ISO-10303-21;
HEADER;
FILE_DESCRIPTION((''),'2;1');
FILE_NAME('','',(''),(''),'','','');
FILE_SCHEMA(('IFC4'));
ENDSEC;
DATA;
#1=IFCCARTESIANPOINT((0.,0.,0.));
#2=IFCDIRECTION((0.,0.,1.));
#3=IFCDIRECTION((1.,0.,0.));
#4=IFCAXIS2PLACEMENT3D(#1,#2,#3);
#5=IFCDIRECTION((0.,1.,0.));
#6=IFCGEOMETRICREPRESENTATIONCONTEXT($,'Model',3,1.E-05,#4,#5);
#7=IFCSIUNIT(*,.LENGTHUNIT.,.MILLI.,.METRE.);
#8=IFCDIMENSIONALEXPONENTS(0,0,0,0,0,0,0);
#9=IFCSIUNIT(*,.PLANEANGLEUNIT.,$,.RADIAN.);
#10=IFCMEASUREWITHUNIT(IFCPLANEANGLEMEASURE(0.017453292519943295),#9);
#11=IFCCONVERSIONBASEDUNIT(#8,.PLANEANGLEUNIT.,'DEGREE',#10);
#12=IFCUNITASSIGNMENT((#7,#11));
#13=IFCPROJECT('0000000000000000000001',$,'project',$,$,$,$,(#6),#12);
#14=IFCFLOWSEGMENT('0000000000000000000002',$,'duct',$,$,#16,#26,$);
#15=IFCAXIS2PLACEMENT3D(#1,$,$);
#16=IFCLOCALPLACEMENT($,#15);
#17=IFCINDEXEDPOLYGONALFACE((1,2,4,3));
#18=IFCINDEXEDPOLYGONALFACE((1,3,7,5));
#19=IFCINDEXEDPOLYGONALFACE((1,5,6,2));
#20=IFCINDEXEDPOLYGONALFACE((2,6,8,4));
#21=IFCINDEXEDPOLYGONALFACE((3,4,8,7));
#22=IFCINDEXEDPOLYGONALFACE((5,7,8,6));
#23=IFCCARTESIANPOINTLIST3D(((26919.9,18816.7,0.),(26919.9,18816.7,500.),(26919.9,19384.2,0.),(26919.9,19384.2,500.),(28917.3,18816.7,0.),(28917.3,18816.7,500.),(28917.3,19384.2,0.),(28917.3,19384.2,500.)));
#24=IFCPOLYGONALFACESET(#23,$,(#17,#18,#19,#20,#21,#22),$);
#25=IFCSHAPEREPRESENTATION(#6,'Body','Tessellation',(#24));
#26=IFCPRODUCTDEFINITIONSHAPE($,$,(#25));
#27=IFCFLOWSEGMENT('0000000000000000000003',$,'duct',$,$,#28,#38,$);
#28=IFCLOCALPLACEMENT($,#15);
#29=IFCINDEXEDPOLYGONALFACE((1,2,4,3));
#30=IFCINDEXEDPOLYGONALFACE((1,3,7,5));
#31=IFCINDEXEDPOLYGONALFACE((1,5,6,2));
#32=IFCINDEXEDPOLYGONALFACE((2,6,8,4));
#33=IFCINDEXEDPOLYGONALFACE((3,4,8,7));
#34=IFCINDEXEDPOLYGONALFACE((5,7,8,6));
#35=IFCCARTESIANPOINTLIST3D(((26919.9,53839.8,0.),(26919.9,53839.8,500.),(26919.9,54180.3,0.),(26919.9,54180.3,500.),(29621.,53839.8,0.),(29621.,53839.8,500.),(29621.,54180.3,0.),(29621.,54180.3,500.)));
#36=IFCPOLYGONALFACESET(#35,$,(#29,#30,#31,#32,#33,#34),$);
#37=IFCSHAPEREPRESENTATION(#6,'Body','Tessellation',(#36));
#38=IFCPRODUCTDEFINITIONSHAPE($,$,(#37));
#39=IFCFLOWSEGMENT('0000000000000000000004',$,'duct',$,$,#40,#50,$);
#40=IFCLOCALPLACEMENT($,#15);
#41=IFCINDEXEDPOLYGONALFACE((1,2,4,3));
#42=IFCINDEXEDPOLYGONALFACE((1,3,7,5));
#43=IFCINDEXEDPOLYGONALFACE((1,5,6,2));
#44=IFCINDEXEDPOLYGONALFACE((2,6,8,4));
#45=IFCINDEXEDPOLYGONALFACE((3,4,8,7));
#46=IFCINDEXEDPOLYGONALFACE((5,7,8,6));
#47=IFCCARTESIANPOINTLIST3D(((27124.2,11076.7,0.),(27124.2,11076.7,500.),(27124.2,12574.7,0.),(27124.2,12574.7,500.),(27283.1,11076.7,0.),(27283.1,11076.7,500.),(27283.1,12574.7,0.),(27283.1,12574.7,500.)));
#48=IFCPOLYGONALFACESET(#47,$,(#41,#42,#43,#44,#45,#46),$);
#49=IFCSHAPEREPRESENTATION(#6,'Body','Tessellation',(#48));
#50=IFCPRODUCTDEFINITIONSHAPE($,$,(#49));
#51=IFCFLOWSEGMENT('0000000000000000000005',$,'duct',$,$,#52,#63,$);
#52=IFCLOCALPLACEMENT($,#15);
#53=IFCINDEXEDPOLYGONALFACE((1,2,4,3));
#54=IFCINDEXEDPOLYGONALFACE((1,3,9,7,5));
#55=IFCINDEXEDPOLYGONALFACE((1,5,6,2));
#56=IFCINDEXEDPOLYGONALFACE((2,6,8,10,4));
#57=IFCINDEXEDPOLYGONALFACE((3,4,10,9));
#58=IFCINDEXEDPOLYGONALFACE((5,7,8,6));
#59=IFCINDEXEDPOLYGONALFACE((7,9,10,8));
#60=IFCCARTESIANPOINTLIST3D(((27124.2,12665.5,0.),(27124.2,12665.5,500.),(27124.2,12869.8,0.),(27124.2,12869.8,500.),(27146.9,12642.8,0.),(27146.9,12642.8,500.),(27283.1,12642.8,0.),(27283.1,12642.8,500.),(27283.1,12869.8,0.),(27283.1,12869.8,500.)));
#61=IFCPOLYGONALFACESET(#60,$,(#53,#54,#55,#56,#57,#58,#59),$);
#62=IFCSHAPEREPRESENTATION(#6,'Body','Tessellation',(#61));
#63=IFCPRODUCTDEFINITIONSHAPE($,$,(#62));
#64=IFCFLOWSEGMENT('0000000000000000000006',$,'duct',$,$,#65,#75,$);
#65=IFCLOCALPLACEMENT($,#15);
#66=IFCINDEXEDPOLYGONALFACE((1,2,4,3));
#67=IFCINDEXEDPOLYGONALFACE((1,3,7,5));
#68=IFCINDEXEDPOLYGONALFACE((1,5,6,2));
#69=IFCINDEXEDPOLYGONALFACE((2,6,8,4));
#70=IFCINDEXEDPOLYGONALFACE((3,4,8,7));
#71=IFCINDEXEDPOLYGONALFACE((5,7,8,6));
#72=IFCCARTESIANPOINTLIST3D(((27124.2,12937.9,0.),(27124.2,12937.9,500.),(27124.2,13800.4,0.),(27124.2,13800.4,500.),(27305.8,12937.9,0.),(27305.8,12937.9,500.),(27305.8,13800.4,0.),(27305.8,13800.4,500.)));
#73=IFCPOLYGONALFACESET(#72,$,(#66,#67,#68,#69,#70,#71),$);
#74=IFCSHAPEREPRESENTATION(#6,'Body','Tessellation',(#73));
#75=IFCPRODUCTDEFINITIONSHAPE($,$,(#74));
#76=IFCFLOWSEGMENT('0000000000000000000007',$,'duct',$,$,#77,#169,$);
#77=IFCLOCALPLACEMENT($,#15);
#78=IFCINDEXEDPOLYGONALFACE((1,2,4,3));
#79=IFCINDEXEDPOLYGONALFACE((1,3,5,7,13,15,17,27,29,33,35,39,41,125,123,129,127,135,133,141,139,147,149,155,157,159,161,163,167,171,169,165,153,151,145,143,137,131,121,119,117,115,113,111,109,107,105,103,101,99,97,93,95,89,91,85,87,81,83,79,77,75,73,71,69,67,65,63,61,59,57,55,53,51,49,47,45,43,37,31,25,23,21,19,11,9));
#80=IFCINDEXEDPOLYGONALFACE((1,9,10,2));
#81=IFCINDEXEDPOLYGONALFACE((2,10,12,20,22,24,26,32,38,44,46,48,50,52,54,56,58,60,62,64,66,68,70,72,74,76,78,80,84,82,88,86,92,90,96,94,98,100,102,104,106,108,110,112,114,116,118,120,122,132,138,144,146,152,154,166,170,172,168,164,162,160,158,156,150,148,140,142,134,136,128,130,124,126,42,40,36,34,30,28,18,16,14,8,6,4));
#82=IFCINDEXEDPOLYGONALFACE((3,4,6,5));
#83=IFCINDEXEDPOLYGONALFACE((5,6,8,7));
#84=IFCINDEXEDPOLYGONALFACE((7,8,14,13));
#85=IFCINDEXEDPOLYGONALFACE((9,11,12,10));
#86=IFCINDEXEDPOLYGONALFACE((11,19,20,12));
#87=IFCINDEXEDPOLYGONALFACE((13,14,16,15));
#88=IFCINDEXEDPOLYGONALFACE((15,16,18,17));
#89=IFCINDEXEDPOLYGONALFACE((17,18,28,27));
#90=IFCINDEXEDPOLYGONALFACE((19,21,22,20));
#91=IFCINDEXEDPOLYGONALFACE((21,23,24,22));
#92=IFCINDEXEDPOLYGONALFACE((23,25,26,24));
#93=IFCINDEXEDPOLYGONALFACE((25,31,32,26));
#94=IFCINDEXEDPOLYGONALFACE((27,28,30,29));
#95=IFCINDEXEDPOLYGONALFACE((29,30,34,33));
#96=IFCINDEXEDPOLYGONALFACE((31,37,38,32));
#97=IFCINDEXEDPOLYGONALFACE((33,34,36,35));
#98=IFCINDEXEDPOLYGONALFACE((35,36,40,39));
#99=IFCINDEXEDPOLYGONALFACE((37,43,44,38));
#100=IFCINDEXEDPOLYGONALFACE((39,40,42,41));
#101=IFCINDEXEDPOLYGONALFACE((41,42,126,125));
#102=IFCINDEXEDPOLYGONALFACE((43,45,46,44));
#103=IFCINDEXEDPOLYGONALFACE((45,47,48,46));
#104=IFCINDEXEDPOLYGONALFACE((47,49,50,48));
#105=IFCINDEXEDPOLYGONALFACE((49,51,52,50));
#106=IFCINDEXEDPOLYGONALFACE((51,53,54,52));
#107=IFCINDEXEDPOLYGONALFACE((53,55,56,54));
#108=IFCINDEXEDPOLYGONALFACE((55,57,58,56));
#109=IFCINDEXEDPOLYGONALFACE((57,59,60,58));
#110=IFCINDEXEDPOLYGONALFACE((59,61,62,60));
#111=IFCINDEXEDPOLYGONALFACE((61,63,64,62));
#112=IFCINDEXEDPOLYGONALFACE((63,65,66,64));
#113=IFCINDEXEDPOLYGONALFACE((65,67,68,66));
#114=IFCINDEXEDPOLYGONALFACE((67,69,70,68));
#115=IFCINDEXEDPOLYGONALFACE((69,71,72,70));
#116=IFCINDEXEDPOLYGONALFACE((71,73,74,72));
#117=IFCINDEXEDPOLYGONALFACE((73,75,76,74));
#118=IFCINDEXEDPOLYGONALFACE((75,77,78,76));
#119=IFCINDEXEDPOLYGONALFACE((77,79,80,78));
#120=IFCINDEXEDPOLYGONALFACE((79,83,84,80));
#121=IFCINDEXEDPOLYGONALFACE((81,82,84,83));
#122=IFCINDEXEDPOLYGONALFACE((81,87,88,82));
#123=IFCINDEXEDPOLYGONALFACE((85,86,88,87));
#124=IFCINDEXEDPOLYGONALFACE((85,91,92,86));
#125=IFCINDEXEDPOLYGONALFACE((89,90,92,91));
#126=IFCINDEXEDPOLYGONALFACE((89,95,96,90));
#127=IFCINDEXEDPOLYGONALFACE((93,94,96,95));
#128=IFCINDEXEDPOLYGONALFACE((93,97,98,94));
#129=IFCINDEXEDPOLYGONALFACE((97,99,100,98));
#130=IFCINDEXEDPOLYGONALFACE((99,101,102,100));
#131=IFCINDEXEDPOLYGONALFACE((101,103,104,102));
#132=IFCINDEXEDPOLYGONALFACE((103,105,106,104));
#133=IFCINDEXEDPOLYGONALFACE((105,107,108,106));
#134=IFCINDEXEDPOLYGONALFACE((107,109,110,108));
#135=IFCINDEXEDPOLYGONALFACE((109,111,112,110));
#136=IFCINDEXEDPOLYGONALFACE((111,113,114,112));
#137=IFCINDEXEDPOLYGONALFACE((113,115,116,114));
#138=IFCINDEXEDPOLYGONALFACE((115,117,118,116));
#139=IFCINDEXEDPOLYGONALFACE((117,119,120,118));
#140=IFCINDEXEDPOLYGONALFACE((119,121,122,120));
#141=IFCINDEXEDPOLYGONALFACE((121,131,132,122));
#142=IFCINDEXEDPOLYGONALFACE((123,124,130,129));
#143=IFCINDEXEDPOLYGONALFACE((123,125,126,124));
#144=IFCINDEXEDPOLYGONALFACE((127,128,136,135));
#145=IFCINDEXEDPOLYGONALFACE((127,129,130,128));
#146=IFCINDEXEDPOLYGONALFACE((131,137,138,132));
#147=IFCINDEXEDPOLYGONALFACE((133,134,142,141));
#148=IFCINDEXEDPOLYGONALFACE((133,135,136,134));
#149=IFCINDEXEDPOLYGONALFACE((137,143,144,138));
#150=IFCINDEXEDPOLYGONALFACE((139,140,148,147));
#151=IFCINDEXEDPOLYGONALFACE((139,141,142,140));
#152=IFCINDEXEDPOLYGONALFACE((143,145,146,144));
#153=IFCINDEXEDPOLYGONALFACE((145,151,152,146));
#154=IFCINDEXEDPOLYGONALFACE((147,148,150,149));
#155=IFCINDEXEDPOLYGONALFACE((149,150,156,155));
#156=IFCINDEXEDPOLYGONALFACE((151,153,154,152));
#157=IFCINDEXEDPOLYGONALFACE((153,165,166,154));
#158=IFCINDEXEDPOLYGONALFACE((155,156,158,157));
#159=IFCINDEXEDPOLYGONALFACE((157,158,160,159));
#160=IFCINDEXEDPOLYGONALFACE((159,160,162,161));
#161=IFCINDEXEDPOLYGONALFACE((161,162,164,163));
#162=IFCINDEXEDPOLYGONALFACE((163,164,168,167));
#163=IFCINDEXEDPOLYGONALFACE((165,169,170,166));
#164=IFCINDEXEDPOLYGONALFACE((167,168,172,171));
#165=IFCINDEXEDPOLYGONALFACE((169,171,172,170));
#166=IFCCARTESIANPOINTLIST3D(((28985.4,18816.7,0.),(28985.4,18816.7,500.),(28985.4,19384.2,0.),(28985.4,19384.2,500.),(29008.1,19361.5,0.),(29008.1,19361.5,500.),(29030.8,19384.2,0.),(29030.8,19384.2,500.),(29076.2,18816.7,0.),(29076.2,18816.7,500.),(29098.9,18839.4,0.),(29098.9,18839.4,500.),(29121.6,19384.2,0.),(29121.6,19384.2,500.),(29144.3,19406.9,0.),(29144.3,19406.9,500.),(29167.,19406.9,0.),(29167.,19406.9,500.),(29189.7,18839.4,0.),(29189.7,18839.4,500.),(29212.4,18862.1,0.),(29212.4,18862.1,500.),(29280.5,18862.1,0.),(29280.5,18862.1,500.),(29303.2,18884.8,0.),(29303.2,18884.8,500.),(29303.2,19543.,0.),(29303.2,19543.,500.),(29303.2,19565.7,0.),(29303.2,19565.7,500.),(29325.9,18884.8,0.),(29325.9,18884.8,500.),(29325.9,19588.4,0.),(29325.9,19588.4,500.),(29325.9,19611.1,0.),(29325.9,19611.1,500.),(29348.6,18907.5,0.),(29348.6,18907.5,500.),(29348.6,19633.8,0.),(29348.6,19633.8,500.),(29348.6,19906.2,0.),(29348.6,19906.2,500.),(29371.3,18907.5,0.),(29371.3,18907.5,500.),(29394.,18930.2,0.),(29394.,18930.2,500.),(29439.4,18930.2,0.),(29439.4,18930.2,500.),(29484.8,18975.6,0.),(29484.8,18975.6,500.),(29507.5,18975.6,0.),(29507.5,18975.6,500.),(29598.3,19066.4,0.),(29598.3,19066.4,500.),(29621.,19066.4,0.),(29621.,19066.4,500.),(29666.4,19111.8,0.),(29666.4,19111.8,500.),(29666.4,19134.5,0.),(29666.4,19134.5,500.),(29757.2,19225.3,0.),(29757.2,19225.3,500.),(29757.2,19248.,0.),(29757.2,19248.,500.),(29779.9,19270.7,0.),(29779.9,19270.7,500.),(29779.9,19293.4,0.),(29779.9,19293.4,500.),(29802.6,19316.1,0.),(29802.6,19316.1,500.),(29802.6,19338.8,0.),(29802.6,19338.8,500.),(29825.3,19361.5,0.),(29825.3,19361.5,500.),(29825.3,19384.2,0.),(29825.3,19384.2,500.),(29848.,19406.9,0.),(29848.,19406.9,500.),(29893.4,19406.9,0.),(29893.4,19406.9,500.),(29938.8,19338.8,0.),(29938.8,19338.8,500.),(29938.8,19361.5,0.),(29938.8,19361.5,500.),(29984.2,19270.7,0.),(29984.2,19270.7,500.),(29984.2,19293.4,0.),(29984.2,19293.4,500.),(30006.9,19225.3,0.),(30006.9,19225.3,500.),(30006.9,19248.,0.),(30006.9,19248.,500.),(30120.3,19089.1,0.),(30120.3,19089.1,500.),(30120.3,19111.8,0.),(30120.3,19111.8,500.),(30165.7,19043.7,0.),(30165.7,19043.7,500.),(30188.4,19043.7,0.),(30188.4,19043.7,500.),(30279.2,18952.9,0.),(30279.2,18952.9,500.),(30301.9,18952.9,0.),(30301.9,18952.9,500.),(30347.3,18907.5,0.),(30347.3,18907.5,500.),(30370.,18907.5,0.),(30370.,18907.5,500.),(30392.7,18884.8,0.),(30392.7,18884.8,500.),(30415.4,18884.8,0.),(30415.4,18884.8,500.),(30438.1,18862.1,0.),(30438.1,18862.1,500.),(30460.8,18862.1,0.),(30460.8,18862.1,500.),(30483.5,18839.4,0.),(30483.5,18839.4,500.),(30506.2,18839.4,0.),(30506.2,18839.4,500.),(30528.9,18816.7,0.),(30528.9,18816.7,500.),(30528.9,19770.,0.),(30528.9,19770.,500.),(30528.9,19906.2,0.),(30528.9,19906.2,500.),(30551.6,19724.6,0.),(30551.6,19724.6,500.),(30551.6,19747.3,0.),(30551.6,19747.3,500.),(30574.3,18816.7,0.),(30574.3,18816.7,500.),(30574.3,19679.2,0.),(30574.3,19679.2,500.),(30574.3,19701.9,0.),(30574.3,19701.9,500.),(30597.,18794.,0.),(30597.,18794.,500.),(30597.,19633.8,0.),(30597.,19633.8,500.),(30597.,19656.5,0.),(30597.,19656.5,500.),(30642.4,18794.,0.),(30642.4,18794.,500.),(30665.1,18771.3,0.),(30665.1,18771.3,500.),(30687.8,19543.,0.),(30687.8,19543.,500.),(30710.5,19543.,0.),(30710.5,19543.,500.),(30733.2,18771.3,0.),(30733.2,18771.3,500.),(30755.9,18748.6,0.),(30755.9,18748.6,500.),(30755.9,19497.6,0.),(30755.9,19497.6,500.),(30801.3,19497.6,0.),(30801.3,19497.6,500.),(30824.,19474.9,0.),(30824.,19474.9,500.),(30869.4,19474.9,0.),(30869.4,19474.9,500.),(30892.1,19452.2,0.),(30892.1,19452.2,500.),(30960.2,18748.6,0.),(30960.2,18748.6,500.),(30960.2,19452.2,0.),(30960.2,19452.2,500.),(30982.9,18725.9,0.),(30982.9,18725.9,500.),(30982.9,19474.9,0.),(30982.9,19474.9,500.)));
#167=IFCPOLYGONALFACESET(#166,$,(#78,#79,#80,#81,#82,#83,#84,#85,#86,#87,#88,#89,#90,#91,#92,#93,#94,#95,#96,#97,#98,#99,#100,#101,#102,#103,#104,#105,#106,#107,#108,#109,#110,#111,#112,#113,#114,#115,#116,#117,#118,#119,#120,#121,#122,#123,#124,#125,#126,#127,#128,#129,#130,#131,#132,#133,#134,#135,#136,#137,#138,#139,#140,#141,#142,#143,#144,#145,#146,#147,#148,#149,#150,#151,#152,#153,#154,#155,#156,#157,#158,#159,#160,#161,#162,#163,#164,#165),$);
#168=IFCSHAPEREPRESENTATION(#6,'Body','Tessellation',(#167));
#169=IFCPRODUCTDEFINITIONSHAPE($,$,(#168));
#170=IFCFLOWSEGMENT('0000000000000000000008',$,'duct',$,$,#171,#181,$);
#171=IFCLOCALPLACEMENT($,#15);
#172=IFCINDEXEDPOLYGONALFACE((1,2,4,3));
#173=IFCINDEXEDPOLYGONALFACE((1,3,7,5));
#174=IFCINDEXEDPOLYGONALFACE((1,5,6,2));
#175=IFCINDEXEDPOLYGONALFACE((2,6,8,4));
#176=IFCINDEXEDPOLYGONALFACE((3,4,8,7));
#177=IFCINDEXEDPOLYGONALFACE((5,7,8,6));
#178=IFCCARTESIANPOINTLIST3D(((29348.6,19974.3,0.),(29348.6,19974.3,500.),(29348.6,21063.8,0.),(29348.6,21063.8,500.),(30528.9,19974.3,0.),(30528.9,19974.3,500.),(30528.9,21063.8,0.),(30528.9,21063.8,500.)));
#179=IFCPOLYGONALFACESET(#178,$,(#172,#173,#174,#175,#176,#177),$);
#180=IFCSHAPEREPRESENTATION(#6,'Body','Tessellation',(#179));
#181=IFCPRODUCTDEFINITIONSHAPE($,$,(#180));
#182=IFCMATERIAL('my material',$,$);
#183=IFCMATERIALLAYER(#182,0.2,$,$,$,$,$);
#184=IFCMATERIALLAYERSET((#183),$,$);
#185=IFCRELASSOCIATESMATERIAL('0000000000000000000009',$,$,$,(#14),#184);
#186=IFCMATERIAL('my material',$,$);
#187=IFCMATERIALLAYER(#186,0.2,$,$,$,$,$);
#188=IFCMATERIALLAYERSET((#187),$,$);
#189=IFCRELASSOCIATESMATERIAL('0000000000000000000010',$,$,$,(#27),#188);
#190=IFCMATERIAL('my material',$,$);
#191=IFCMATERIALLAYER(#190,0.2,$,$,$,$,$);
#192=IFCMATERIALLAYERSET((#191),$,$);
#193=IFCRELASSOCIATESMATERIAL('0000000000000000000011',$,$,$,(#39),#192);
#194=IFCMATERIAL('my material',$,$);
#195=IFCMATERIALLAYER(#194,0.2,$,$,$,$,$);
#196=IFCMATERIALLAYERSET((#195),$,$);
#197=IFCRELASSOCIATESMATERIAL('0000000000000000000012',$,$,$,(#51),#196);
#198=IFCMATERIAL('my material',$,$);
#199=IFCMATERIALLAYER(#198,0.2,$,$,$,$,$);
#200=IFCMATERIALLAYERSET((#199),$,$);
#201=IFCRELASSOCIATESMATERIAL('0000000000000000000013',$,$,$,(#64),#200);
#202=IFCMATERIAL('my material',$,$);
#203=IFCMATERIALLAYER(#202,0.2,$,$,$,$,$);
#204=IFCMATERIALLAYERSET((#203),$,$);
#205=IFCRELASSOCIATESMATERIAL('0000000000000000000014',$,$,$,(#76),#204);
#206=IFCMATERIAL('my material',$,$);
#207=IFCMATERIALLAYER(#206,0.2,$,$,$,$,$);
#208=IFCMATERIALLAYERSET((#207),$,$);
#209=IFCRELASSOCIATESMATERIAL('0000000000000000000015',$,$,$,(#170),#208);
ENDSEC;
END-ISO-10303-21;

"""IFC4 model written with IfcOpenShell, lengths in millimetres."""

from ifc_helpers import new_model, entity, si_unit, converted_unit, direction, origin_with_axes, place, context, project, polyline, outline, extrude, material, layer, layer_set, layer_usage, element, save


model = new_model("IFC4")

# Units and contexts
model_context = context("Model", 3, precision=1e-05, world=origin_with_axes(), true_north=direction((0.0, 1.0, 0.0)))
ifc_project = project(units=[si_unit("LENGTHUNIT", "METRE", prefix="MILLI"), converted_unit("PLANEANGLEUNIT", "DEGREE", entity("IfcPlaneAngleMeasure", 0.017453292519943295), si_unit("PLANEANGLEUNIT", "RADIAN"), dimensions=[0, 0, 0, 0, 0, 0, 0])], contexts=[model_context])

# Flow segments
ifc_material_1 = material(Name="my material")
ifc_layer_1 = layer(ifc_material_1, 0.2)
ifc_layer_set_1 = layer_set([ifc_layer_1])
ifc_layer_usage_1 = layer_usage(ifc_layer_set_1, "AXIS2", "POSITIVE", -0.1)
flow_segment_1_placement = place(None, origin_with_axes())
element("IfcFlowSegment", 1, at=flow_segment_1_placement, material=ifc_layer_usage_1, Name="duct", context=model_context, shape_type="SweptSolid", body=[
    extrude(outline(polyline([(26919.9, 18816.7), (28917.3, 18816.7), (28917.3, 19384.2), (26919.9, 19384.2), (26919.9, 18816.7)])), origin_with_axes(), (0.0, 0.0, 1.0), 500.0),
])
ifc_material_2 = material(Name="my material")
ifc_layer_2 = layer(ifc_material_2, 0.2)
ifc_layer_set_2 = layer_set([ifc_layer_2])
ifc_layer_usage_2 = layer_usage(ifc_layer_set_2, "AXIS2", "POSITIVE", -0.1)
flow_segment_2_placement = place(None, origin_with_axes())
element("IfcFlowSegment", 2, at=flow_segment_2_placement, material=ifc_layer_usage_2, Name="duct", context=model_context, shape_type="SweptSolid", body=[
    extrude(outline(polyline([(26919.9, 53839.8), (29621.0, 53839.8), (29621.0, 54180.3), (26919.9, 54180.3), (26919.9, 53839.8)])), origin_with_axes(), (0.0, 0.0, 1.0), 500.0),
])
ifc_material_3 = material(Name="my material")
ifc_layer_3 = layer(ifc_material_3, 0.2)
ifc_layer_set_3 = layer_set([ifc_layer_3])
ifc_layer_usage_3 = layer_usage(ifc_layer_set_3, "AXIS2", "POSITIVE", -0.1)
flow_segment_3_placement = place(None, origin_with_axes())
element("IfcFlowSegment", 3, at=flow_segment_3_placement, material=ifc_layer_usage_3, Name="duct", context=model_context, shape_type="SweptSolid", body=[
    extrude(outline(polyline([(27124.2, 11076.7), (27283.1, 11076.7), (27283.1, 12574.7), (27124.2, 12574.7), (27124.2, 11076.7)])), origin_with_axes(), (0.0, 0.0, 1.0), 500.0),
])
ifc_material_4 = material(Name="my material")
ifc_layer_4 = layer(ifc_material_4, 0.2)
ifc_layer_set_4 = layer_set([ifc_layer_4])
ifc_layer_usage_4 = layer_usage(ifc_layer_set_4, "AXIS2", "POSITIVE", -0.1)
flow_segment_4_placement = place(None, origin_with_axes())
element("IfcFlowSegment", 4, at=flow_segment_4_placement, material=ifc_layer_usage_4, Name="duct", context=model_context, shape_type="SweptSolid", body=[
    extrude(outline(polyline([(27124.2, 12665.5), (27146.9, 12642.8), (27283.1, 12642.8), (27283.1, 12869.8), (27124.2, 12869.8), (27124.2, 12665.5)])), origin_with_axes(), (0.0, 0.0, 1.0), 500.0),
])
ifc_material_5 = material(Name="my material")
ifc_layer_5 = layer(ifc_material_5, 0.2)
ifc_layer_set_5 = layer_set([ifc_layer_5])
ifc_layer_usage_5 = layer_usage(ifc_layer_set_5, "AXIS2", "POSITIVE", -0.1)
flow_segment_5_placement = place(None, origin_with_axes())
element("IfcFlowSegment", 5, at=flow_segment_5_placement, material=ifc_layer_usage_5, Name="duct", context=model_context, shape_type="SweptSolid", body=[
    extrude(outline(polyline([(27124.2, 12937.9), (27305.8, 12937.9), (27305.8, 13800.4), (27124.2, 13800.4), (27124.2, 12937.9)])), origin_with_axes(), (0.0, 0.0, 1.0), 500.0),
])
ifc_material_6 = material(Name="my material")
ifc_layer_6 = layer(ifc_material_6, 0.2)
ifc_layer_set_6 = layer_set([ifc_layer_6])
ifc_layer_usage_6 = layer_usage(ifc_layer_set_6, "AXIS2", "POSITIVE", -0.1)
flow_segment_6_placement = place(None, origin_with_axes())
element("IfcFlowSegment", 6, at=flow_segment_6_placement, material=ifc_layer_usage_6, Name="duct", context=model_context, shape_type="SweptSolid", body=[
    extrude(outline(polyline([(28985.4, 18816.7), (29076.2, 18816.7), (29098.9, 18839.4), (29189.7, 18839.4), (29212.4, 18862.1), (29280.5, 18862.1), (29303.2, 18884.8), (29325.9, 18884.8), (29348.6, 18907.5), (29371.3, 18907.5), (29394.0, 18930.2), (29439.4, 18930.2), (29484.8, 18975.6), (29507.5, 18975.6), (29598.3, 19066.4), (29621.0, 19066.4), (29666.4, 19111.8), (29666.4, 19134.5), (29757.2, 19225.3), (29757.2, 19248.0), (29779.9, 19270.7), (29779.9, 19293.4), (29802.6, 19316.1), (29802.6, 19338.8), (29825.3, 19361.5), (29825.3, 19384.2), (29848.0, 19406.9), (29893.4, 19406.9), (29938.8, 19361.5), (29938.8, 19338.8), (29984.2, 19293.4), (29984.2, 19270.7), (30006.9, 19248.0), (30006.9, 19225.3), (30120.3, 19111.8), (30120.3, 19089.1), (30165.7, 19043.7), (30188.4, 19043.7), (30279.2, 18952.9), (30301.9, 18952.9), (30347.3, 18907.5), (30370.0, 18907.5), (30392.7, 18884.8), (30415.4, 18884.8), (30438.1, 18862.1), (30460.8, 18862.1), (30483.5, 18839.4), (30506.2, 18839.4), (30528.9, 18816.7), (30574.3, 18816.7), (30597.0, 18794.0), (30642.4, 18794.0), (30665.1, 18771.3), (30733.2, 18771.3), (30755.9, 18748.6), (30960.2, 18748.6), (30982.9, 18725.9), (30982.9, 19474.9), (30960.2, 19452.2), (30892.1, 19452.2), (30869.4, 19474.9), (30824.0, 19474.9), (30801.3, 19497.6), (30755.9, 19497.6), (30710.5, 19543.0), (30687.8, 19543.0), (30597.0, 19633.8), (30597.0, 19656.5), (30574.3, 19679.2), (30574.3, 19701.9), (30551.6, 19724.6), (30551.6, 19747.3), (30528.9, 19770.0), (30528.9, 19906.2), (29348.6, 19906.2), (29348.6, 19633.8), (29325.9, 19611.1), (29325.9, 19588.4), (29303.2, 19565.7), (29303.2, 19543.0), (29167.0, 19406.9), (29144.3, 19406.9), (29121.6, 19384.2), (29030.8, 19384.2), (29008.1, 19361.5), (28985.4, 19384.2), (28985.4, 18816.7)])), origin_with_axes(), (0.0, 0.0, 1.0), 500.0),
])
ifc_material_7 = material(Name="my material")
ifc_layer_7 = layer(ifc_material_7, 0.2)
ifc_layer_set_7 = layer_set([ifc_layer_7])
ifc_layer_usage_7 = layer_usage(ifc_layer_set_7, "AXIS2", "POSITIVE", -0.1)
flow_segment_7_placement = place(None, origin_with_axes())
element("IfcFlowSegment", 7, at=flow_segment_7_placement, material=ifc_layer_usage_7, Name="duct", context=model_context, shape_type="SweptSolid", body=[
    extrude(outline(polyline([(29348.6, 19974.3), (30528.9, 19974.3), (30528.9, 21063.8), (29348.6, 21063.8), (29348.6, 19974.3)])), origin_with_axes(), (0.0, 0.0, 1.0), 500.0),
])

save(model, "model.ifc")
